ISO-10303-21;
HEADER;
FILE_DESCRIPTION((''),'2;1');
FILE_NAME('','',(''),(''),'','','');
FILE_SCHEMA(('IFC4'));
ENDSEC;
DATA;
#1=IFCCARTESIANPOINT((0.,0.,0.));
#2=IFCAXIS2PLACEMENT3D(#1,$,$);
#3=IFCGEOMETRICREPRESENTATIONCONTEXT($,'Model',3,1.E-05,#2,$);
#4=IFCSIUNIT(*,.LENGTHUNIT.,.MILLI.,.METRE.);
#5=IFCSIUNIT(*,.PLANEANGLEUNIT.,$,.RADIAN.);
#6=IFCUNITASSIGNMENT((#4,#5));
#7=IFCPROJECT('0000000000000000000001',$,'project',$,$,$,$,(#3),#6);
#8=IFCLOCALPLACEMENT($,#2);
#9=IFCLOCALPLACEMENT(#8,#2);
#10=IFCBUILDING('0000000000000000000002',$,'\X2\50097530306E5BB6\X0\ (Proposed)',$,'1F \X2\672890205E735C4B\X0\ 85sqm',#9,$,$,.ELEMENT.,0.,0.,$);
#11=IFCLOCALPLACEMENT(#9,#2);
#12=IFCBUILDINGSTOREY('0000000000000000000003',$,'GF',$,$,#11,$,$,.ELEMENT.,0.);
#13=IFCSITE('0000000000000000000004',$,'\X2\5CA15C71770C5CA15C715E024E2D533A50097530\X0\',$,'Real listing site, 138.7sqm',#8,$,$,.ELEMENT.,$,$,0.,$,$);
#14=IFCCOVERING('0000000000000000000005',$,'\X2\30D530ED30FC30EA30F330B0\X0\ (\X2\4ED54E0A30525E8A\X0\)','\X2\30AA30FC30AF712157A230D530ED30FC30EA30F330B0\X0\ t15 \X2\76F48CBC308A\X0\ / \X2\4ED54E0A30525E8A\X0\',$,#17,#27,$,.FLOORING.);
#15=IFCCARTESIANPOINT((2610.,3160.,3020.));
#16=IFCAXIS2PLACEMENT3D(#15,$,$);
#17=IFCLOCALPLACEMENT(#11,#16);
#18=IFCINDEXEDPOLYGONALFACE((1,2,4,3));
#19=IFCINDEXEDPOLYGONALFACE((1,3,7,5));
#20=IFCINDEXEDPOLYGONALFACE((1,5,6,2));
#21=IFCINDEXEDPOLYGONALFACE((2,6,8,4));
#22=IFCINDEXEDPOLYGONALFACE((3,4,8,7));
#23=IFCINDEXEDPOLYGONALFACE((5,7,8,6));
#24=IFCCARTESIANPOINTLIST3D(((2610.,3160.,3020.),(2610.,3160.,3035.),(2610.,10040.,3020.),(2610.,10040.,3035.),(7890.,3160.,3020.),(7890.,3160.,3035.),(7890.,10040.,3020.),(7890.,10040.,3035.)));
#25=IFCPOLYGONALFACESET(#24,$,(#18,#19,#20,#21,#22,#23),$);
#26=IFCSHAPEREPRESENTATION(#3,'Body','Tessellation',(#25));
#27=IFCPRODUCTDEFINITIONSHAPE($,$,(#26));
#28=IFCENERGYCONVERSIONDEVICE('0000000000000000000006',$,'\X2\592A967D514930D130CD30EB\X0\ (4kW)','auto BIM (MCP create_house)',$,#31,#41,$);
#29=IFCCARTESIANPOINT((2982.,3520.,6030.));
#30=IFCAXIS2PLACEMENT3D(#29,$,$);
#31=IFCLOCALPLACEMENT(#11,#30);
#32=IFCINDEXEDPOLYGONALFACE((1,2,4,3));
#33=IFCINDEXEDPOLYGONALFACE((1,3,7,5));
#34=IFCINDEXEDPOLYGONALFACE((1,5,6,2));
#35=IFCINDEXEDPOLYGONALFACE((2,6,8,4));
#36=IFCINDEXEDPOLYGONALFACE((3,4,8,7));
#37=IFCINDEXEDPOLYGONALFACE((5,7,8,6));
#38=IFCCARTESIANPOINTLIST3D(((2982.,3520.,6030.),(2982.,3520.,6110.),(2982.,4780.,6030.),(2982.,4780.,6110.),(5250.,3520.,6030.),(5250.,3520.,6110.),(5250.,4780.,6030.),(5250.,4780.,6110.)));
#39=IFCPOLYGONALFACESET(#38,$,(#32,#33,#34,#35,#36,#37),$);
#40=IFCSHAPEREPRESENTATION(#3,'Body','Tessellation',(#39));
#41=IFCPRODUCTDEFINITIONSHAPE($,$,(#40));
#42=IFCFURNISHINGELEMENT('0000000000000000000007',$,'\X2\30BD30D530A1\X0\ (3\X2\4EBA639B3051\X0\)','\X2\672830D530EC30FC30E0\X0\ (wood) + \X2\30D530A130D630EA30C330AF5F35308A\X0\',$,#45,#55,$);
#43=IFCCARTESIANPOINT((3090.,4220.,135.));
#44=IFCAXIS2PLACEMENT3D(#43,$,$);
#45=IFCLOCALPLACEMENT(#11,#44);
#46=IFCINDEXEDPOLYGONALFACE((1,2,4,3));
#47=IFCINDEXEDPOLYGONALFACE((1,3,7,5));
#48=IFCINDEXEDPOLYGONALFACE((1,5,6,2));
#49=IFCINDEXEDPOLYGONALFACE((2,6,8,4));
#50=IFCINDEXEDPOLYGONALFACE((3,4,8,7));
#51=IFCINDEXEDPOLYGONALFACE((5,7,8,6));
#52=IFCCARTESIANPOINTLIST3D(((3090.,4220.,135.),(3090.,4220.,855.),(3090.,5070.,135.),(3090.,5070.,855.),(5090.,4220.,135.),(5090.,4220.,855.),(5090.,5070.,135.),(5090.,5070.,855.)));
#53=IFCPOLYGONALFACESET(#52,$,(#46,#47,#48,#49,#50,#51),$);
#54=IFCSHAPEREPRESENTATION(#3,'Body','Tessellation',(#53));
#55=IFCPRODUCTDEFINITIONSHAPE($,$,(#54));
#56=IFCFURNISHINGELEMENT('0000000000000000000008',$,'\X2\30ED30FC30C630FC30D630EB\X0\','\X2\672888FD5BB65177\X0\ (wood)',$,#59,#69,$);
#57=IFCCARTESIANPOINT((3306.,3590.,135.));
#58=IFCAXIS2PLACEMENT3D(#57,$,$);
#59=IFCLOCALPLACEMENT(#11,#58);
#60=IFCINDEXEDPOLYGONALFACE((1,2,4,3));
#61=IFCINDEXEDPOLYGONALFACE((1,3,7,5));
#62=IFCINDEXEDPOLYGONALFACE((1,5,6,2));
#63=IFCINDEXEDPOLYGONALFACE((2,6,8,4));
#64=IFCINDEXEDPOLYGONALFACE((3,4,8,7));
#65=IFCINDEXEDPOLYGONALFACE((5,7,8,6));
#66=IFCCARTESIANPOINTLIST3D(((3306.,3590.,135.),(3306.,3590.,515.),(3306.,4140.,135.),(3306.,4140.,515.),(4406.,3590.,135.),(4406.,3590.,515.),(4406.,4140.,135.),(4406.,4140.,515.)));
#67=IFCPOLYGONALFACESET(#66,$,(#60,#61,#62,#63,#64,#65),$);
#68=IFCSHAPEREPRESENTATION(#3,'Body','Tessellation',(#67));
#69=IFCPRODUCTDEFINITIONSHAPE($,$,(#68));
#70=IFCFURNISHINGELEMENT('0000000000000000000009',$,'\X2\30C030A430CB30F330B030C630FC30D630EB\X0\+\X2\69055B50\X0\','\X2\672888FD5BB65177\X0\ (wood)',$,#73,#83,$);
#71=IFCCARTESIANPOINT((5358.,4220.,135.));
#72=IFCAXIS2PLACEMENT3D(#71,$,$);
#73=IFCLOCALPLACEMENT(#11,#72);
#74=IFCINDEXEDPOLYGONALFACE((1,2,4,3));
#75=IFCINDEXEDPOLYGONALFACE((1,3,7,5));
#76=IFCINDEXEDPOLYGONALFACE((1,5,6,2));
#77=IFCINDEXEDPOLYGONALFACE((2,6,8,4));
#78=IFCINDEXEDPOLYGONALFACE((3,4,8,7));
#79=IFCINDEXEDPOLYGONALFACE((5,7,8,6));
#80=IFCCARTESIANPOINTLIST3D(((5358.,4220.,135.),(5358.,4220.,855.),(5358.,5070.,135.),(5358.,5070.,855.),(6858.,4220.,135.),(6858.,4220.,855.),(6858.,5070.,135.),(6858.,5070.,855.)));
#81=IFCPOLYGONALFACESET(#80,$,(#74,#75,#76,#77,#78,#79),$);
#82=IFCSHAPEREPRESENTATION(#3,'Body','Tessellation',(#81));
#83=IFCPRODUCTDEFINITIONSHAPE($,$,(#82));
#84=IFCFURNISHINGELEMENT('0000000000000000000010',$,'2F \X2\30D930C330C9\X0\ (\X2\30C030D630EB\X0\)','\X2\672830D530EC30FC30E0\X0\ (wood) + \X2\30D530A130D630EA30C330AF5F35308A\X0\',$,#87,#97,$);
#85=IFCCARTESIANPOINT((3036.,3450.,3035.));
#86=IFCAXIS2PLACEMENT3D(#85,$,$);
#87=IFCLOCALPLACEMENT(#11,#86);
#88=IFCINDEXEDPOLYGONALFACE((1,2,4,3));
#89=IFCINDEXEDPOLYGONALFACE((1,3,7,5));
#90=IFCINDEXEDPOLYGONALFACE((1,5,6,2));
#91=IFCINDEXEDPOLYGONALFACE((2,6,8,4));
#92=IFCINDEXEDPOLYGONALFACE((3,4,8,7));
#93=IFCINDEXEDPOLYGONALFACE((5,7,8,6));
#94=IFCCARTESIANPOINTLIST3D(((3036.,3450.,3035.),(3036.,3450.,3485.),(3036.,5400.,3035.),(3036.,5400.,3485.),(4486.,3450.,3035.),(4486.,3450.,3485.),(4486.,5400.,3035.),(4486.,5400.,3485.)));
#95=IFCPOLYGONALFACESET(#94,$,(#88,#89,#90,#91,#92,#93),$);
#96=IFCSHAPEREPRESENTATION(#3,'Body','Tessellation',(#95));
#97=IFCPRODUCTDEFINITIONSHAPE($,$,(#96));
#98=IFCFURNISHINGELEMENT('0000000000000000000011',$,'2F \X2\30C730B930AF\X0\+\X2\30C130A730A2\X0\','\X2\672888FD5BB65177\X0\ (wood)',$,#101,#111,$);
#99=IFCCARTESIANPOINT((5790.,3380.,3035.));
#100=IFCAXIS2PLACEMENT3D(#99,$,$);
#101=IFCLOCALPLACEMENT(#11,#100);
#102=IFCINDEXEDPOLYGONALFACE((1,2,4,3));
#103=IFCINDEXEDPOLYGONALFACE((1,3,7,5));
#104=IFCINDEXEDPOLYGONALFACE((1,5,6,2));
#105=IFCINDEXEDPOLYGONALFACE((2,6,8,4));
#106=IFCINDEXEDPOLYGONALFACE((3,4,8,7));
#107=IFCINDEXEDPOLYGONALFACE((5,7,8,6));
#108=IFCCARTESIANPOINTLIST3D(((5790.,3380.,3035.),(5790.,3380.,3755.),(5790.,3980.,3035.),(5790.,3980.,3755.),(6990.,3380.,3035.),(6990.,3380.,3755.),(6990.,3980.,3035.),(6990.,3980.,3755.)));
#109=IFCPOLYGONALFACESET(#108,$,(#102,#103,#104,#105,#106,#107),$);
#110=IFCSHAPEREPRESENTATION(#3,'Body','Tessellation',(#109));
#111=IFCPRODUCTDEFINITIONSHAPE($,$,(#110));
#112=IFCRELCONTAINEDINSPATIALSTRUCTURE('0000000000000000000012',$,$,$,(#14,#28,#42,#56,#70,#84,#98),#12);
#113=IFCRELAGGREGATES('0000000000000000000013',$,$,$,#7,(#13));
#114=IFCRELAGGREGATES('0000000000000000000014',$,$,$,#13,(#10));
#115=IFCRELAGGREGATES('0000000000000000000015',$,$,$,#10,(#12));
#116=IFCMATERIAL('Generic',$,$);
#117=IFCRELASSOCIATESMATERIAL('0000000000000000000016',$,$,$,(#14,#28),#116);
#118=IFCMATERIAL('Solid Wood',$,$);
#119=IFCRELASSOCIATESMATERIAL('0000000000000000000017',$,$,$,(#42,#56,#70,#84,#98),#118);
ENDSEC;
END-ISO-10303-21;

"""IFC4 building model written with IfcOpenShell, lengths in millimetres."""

from ifc_helpers import new_model, si_unit, frame, frame_2d, origin, place, context, project, spatial, rectangle, extrude, material, element, save


model = new_model("IFC4")

# Units and contexts
model_context = context("Model", 3, precision=1e-05, world=origin())
ifc_project = project(units=[si_unit("LENGTHUNIT", "METRE", prefix="MILLI"), si_unit("PLANEANGLEUNIT", "RADIAN")], contexts=[model_context])

# Site, building, storey
site_placement = place(None, origin())
site = spatial("IfcSite", under=ifc_project, at=site_placement, Name="岡山県岡山市中区倉田", ObjectType="Real listing site, 138.7sqm", CompositionType="ELEMENT", RefElevation=0.0)
building_placement = place(site_placement, origin())
building = spatial("IfcBuilding", under=site, at=building_placement, Name="倉田の家 (Proposed)", ObjectType="1F 木造平屋 85sqm", CompositionType="ELEMENT", ElevationOfRefHeight=0.0, ElevationOfTerrain=0.0)
storey_placement = place(building_placement, origin())
storey = spatial("IfcBuildingStorey", under=building, at=storey_placement, Name="GF", CompositionType="ELEMENT", Elevation=0.0)

# Shared definitions
ifc_material_1 = material(Name="Solid Wood")

# Shared definitions
ifc_material_2 = material(Name="Generic")

# Covering
covering_placement = place(storey_placement, frame((2610.0, 3160.0, 3020.0)))
element("IfcCovering", 1, at=covering_placement, inside=storey, material=ifc_material_2, Name="フローリング (仕上げ床)", Description="オーク無垢フローリング t15 直貼り / 仕上げ床", PredefinedType="FLOORING", context=model_context, shape_type="SweptSolid", body=[
    extrude(rectangle(XDim=5280.0, YDim=6880.0, at=frame_2d((2640.0, 3440.0))), frame((2610.0, 3160.0, 3020.0)), (0.0, 0.0, 1.0), 15.0),
])

# Energy conversion device
energy_conversion_device_placement = place(storey_placement, frame((2982.0, 3520.0, 6030.0)))
element("IfcEnergyConversionDevice", 2, at=energy_conversion_device_placement, inside=storey, material=ifc_material_2, Name="太陽光パネル (4kW)", Description="auto BIM (MCP create_house)", context=model_context, shape_type="SweptSolid", body=[
    extrude(rectangle(XDim=2268.0, YDim=1260.0, at=frame_2d((1134.0, 630.0))), frame((2982.0, 3520.0, 6030.0)), (0.0, 0.0, 1.0), 80.0),
])

# Furnishing elements
furnishing_1_placement = place(storey_placement, frame((3090.0, 4220.0, 135.0)))
element("IfcFurnishingElement", 3, at=furnishing_1_placement, inside=storey, material=ifc_material_1, Name="ソファ (3人掛け)", Description="木フレーム (wood) + ファブリック張り", context=model_context, shape_type="SweptSolid", body=[
    extrude(rectangle(XDim=2000.0, YDim=850.0, at=frame_2d((1000.0, 425.0))), frame((3090.0, 4220.0, 135.0)), (0.0, 0.0, 1.0), 720.0),
])
furnishing_2_placement = place(storey_placement, frame((3306.0, 3590.0, 135.0)))
element("IfcFurnishingElement", 4, at=furnishing_2_placement, inside=storey, material=ifc_material_1, Name="ローテーブル", Description="木製家具 (wood)", context=model_context, shape_type="SweptSolid", body=[
    extrude(rectangle(XDim=1100.0, YDim=550.0, at=frame_2d((550.0, 275.0))), frame((3306.0, 3590.0, 135.0)), (0.0, 0.0, 1.0), 380.0),
])
furnishing_3_placement = place(storey_placement, frame((5358.0, 4220.0, 135.0)))
element("IfcFurnishingElement", 5, at=furnishing_3_placement, inside=storey, material=ifc_material_1, Name="ダイニングテーブル+椅子", Description="木製家具 (wood)", context=model_context, shape_type="SweptSolid", body=[
    extrude(rectangle(XDim=1500.0, YDim=850.0, at=frame_2d((750.0, 425.0))), frame((5358.0, 4220.0, 135.0)), (0.0, 0.0, 1.0), 720.0),
])
furnishing_4_placement = place(storey_placement, frame((3036.0, 3450.0, 3035.0)))
element("IfcFurnishingElement", 6, at=furnishing_4_placement, inside=storey, material=ifc_material_1, Name="2F ベッド (ダブル)", Description="木フレーム (wood) + ファブリック張り", context=model_context, shape_type="SweptSolid", body=[
    extrude(rectangle(XDim=1450.0, YDim=1950.0, at=frame_2d((725.0, 975.0))), frame((3036.0, 3450.0, 3035.0)), (0.0, 0.0, 1.0), 450.0),
])
furnishing_5_placement = place(storey_placement, frame((5790.0, 3380.0, 3035.0)))
element("IfcFurnishingElement", 7, at=furnishing_5_placement, inside=storey, material=ifc_material_1, Name="2F デスク+チェア", Description="木製家具 (wood)", context=model_context, shape_type="SweptSolid", body=[
    extrude(rectangle(XDim=1200.0, YDim=600.0, at=frame_2d((600.0, 300.0))), frame((5790.0, 3380.0, 3035.0)), (0.0, 0.0, 1.0), 720.0),
])

save(model, "model.ifc")
